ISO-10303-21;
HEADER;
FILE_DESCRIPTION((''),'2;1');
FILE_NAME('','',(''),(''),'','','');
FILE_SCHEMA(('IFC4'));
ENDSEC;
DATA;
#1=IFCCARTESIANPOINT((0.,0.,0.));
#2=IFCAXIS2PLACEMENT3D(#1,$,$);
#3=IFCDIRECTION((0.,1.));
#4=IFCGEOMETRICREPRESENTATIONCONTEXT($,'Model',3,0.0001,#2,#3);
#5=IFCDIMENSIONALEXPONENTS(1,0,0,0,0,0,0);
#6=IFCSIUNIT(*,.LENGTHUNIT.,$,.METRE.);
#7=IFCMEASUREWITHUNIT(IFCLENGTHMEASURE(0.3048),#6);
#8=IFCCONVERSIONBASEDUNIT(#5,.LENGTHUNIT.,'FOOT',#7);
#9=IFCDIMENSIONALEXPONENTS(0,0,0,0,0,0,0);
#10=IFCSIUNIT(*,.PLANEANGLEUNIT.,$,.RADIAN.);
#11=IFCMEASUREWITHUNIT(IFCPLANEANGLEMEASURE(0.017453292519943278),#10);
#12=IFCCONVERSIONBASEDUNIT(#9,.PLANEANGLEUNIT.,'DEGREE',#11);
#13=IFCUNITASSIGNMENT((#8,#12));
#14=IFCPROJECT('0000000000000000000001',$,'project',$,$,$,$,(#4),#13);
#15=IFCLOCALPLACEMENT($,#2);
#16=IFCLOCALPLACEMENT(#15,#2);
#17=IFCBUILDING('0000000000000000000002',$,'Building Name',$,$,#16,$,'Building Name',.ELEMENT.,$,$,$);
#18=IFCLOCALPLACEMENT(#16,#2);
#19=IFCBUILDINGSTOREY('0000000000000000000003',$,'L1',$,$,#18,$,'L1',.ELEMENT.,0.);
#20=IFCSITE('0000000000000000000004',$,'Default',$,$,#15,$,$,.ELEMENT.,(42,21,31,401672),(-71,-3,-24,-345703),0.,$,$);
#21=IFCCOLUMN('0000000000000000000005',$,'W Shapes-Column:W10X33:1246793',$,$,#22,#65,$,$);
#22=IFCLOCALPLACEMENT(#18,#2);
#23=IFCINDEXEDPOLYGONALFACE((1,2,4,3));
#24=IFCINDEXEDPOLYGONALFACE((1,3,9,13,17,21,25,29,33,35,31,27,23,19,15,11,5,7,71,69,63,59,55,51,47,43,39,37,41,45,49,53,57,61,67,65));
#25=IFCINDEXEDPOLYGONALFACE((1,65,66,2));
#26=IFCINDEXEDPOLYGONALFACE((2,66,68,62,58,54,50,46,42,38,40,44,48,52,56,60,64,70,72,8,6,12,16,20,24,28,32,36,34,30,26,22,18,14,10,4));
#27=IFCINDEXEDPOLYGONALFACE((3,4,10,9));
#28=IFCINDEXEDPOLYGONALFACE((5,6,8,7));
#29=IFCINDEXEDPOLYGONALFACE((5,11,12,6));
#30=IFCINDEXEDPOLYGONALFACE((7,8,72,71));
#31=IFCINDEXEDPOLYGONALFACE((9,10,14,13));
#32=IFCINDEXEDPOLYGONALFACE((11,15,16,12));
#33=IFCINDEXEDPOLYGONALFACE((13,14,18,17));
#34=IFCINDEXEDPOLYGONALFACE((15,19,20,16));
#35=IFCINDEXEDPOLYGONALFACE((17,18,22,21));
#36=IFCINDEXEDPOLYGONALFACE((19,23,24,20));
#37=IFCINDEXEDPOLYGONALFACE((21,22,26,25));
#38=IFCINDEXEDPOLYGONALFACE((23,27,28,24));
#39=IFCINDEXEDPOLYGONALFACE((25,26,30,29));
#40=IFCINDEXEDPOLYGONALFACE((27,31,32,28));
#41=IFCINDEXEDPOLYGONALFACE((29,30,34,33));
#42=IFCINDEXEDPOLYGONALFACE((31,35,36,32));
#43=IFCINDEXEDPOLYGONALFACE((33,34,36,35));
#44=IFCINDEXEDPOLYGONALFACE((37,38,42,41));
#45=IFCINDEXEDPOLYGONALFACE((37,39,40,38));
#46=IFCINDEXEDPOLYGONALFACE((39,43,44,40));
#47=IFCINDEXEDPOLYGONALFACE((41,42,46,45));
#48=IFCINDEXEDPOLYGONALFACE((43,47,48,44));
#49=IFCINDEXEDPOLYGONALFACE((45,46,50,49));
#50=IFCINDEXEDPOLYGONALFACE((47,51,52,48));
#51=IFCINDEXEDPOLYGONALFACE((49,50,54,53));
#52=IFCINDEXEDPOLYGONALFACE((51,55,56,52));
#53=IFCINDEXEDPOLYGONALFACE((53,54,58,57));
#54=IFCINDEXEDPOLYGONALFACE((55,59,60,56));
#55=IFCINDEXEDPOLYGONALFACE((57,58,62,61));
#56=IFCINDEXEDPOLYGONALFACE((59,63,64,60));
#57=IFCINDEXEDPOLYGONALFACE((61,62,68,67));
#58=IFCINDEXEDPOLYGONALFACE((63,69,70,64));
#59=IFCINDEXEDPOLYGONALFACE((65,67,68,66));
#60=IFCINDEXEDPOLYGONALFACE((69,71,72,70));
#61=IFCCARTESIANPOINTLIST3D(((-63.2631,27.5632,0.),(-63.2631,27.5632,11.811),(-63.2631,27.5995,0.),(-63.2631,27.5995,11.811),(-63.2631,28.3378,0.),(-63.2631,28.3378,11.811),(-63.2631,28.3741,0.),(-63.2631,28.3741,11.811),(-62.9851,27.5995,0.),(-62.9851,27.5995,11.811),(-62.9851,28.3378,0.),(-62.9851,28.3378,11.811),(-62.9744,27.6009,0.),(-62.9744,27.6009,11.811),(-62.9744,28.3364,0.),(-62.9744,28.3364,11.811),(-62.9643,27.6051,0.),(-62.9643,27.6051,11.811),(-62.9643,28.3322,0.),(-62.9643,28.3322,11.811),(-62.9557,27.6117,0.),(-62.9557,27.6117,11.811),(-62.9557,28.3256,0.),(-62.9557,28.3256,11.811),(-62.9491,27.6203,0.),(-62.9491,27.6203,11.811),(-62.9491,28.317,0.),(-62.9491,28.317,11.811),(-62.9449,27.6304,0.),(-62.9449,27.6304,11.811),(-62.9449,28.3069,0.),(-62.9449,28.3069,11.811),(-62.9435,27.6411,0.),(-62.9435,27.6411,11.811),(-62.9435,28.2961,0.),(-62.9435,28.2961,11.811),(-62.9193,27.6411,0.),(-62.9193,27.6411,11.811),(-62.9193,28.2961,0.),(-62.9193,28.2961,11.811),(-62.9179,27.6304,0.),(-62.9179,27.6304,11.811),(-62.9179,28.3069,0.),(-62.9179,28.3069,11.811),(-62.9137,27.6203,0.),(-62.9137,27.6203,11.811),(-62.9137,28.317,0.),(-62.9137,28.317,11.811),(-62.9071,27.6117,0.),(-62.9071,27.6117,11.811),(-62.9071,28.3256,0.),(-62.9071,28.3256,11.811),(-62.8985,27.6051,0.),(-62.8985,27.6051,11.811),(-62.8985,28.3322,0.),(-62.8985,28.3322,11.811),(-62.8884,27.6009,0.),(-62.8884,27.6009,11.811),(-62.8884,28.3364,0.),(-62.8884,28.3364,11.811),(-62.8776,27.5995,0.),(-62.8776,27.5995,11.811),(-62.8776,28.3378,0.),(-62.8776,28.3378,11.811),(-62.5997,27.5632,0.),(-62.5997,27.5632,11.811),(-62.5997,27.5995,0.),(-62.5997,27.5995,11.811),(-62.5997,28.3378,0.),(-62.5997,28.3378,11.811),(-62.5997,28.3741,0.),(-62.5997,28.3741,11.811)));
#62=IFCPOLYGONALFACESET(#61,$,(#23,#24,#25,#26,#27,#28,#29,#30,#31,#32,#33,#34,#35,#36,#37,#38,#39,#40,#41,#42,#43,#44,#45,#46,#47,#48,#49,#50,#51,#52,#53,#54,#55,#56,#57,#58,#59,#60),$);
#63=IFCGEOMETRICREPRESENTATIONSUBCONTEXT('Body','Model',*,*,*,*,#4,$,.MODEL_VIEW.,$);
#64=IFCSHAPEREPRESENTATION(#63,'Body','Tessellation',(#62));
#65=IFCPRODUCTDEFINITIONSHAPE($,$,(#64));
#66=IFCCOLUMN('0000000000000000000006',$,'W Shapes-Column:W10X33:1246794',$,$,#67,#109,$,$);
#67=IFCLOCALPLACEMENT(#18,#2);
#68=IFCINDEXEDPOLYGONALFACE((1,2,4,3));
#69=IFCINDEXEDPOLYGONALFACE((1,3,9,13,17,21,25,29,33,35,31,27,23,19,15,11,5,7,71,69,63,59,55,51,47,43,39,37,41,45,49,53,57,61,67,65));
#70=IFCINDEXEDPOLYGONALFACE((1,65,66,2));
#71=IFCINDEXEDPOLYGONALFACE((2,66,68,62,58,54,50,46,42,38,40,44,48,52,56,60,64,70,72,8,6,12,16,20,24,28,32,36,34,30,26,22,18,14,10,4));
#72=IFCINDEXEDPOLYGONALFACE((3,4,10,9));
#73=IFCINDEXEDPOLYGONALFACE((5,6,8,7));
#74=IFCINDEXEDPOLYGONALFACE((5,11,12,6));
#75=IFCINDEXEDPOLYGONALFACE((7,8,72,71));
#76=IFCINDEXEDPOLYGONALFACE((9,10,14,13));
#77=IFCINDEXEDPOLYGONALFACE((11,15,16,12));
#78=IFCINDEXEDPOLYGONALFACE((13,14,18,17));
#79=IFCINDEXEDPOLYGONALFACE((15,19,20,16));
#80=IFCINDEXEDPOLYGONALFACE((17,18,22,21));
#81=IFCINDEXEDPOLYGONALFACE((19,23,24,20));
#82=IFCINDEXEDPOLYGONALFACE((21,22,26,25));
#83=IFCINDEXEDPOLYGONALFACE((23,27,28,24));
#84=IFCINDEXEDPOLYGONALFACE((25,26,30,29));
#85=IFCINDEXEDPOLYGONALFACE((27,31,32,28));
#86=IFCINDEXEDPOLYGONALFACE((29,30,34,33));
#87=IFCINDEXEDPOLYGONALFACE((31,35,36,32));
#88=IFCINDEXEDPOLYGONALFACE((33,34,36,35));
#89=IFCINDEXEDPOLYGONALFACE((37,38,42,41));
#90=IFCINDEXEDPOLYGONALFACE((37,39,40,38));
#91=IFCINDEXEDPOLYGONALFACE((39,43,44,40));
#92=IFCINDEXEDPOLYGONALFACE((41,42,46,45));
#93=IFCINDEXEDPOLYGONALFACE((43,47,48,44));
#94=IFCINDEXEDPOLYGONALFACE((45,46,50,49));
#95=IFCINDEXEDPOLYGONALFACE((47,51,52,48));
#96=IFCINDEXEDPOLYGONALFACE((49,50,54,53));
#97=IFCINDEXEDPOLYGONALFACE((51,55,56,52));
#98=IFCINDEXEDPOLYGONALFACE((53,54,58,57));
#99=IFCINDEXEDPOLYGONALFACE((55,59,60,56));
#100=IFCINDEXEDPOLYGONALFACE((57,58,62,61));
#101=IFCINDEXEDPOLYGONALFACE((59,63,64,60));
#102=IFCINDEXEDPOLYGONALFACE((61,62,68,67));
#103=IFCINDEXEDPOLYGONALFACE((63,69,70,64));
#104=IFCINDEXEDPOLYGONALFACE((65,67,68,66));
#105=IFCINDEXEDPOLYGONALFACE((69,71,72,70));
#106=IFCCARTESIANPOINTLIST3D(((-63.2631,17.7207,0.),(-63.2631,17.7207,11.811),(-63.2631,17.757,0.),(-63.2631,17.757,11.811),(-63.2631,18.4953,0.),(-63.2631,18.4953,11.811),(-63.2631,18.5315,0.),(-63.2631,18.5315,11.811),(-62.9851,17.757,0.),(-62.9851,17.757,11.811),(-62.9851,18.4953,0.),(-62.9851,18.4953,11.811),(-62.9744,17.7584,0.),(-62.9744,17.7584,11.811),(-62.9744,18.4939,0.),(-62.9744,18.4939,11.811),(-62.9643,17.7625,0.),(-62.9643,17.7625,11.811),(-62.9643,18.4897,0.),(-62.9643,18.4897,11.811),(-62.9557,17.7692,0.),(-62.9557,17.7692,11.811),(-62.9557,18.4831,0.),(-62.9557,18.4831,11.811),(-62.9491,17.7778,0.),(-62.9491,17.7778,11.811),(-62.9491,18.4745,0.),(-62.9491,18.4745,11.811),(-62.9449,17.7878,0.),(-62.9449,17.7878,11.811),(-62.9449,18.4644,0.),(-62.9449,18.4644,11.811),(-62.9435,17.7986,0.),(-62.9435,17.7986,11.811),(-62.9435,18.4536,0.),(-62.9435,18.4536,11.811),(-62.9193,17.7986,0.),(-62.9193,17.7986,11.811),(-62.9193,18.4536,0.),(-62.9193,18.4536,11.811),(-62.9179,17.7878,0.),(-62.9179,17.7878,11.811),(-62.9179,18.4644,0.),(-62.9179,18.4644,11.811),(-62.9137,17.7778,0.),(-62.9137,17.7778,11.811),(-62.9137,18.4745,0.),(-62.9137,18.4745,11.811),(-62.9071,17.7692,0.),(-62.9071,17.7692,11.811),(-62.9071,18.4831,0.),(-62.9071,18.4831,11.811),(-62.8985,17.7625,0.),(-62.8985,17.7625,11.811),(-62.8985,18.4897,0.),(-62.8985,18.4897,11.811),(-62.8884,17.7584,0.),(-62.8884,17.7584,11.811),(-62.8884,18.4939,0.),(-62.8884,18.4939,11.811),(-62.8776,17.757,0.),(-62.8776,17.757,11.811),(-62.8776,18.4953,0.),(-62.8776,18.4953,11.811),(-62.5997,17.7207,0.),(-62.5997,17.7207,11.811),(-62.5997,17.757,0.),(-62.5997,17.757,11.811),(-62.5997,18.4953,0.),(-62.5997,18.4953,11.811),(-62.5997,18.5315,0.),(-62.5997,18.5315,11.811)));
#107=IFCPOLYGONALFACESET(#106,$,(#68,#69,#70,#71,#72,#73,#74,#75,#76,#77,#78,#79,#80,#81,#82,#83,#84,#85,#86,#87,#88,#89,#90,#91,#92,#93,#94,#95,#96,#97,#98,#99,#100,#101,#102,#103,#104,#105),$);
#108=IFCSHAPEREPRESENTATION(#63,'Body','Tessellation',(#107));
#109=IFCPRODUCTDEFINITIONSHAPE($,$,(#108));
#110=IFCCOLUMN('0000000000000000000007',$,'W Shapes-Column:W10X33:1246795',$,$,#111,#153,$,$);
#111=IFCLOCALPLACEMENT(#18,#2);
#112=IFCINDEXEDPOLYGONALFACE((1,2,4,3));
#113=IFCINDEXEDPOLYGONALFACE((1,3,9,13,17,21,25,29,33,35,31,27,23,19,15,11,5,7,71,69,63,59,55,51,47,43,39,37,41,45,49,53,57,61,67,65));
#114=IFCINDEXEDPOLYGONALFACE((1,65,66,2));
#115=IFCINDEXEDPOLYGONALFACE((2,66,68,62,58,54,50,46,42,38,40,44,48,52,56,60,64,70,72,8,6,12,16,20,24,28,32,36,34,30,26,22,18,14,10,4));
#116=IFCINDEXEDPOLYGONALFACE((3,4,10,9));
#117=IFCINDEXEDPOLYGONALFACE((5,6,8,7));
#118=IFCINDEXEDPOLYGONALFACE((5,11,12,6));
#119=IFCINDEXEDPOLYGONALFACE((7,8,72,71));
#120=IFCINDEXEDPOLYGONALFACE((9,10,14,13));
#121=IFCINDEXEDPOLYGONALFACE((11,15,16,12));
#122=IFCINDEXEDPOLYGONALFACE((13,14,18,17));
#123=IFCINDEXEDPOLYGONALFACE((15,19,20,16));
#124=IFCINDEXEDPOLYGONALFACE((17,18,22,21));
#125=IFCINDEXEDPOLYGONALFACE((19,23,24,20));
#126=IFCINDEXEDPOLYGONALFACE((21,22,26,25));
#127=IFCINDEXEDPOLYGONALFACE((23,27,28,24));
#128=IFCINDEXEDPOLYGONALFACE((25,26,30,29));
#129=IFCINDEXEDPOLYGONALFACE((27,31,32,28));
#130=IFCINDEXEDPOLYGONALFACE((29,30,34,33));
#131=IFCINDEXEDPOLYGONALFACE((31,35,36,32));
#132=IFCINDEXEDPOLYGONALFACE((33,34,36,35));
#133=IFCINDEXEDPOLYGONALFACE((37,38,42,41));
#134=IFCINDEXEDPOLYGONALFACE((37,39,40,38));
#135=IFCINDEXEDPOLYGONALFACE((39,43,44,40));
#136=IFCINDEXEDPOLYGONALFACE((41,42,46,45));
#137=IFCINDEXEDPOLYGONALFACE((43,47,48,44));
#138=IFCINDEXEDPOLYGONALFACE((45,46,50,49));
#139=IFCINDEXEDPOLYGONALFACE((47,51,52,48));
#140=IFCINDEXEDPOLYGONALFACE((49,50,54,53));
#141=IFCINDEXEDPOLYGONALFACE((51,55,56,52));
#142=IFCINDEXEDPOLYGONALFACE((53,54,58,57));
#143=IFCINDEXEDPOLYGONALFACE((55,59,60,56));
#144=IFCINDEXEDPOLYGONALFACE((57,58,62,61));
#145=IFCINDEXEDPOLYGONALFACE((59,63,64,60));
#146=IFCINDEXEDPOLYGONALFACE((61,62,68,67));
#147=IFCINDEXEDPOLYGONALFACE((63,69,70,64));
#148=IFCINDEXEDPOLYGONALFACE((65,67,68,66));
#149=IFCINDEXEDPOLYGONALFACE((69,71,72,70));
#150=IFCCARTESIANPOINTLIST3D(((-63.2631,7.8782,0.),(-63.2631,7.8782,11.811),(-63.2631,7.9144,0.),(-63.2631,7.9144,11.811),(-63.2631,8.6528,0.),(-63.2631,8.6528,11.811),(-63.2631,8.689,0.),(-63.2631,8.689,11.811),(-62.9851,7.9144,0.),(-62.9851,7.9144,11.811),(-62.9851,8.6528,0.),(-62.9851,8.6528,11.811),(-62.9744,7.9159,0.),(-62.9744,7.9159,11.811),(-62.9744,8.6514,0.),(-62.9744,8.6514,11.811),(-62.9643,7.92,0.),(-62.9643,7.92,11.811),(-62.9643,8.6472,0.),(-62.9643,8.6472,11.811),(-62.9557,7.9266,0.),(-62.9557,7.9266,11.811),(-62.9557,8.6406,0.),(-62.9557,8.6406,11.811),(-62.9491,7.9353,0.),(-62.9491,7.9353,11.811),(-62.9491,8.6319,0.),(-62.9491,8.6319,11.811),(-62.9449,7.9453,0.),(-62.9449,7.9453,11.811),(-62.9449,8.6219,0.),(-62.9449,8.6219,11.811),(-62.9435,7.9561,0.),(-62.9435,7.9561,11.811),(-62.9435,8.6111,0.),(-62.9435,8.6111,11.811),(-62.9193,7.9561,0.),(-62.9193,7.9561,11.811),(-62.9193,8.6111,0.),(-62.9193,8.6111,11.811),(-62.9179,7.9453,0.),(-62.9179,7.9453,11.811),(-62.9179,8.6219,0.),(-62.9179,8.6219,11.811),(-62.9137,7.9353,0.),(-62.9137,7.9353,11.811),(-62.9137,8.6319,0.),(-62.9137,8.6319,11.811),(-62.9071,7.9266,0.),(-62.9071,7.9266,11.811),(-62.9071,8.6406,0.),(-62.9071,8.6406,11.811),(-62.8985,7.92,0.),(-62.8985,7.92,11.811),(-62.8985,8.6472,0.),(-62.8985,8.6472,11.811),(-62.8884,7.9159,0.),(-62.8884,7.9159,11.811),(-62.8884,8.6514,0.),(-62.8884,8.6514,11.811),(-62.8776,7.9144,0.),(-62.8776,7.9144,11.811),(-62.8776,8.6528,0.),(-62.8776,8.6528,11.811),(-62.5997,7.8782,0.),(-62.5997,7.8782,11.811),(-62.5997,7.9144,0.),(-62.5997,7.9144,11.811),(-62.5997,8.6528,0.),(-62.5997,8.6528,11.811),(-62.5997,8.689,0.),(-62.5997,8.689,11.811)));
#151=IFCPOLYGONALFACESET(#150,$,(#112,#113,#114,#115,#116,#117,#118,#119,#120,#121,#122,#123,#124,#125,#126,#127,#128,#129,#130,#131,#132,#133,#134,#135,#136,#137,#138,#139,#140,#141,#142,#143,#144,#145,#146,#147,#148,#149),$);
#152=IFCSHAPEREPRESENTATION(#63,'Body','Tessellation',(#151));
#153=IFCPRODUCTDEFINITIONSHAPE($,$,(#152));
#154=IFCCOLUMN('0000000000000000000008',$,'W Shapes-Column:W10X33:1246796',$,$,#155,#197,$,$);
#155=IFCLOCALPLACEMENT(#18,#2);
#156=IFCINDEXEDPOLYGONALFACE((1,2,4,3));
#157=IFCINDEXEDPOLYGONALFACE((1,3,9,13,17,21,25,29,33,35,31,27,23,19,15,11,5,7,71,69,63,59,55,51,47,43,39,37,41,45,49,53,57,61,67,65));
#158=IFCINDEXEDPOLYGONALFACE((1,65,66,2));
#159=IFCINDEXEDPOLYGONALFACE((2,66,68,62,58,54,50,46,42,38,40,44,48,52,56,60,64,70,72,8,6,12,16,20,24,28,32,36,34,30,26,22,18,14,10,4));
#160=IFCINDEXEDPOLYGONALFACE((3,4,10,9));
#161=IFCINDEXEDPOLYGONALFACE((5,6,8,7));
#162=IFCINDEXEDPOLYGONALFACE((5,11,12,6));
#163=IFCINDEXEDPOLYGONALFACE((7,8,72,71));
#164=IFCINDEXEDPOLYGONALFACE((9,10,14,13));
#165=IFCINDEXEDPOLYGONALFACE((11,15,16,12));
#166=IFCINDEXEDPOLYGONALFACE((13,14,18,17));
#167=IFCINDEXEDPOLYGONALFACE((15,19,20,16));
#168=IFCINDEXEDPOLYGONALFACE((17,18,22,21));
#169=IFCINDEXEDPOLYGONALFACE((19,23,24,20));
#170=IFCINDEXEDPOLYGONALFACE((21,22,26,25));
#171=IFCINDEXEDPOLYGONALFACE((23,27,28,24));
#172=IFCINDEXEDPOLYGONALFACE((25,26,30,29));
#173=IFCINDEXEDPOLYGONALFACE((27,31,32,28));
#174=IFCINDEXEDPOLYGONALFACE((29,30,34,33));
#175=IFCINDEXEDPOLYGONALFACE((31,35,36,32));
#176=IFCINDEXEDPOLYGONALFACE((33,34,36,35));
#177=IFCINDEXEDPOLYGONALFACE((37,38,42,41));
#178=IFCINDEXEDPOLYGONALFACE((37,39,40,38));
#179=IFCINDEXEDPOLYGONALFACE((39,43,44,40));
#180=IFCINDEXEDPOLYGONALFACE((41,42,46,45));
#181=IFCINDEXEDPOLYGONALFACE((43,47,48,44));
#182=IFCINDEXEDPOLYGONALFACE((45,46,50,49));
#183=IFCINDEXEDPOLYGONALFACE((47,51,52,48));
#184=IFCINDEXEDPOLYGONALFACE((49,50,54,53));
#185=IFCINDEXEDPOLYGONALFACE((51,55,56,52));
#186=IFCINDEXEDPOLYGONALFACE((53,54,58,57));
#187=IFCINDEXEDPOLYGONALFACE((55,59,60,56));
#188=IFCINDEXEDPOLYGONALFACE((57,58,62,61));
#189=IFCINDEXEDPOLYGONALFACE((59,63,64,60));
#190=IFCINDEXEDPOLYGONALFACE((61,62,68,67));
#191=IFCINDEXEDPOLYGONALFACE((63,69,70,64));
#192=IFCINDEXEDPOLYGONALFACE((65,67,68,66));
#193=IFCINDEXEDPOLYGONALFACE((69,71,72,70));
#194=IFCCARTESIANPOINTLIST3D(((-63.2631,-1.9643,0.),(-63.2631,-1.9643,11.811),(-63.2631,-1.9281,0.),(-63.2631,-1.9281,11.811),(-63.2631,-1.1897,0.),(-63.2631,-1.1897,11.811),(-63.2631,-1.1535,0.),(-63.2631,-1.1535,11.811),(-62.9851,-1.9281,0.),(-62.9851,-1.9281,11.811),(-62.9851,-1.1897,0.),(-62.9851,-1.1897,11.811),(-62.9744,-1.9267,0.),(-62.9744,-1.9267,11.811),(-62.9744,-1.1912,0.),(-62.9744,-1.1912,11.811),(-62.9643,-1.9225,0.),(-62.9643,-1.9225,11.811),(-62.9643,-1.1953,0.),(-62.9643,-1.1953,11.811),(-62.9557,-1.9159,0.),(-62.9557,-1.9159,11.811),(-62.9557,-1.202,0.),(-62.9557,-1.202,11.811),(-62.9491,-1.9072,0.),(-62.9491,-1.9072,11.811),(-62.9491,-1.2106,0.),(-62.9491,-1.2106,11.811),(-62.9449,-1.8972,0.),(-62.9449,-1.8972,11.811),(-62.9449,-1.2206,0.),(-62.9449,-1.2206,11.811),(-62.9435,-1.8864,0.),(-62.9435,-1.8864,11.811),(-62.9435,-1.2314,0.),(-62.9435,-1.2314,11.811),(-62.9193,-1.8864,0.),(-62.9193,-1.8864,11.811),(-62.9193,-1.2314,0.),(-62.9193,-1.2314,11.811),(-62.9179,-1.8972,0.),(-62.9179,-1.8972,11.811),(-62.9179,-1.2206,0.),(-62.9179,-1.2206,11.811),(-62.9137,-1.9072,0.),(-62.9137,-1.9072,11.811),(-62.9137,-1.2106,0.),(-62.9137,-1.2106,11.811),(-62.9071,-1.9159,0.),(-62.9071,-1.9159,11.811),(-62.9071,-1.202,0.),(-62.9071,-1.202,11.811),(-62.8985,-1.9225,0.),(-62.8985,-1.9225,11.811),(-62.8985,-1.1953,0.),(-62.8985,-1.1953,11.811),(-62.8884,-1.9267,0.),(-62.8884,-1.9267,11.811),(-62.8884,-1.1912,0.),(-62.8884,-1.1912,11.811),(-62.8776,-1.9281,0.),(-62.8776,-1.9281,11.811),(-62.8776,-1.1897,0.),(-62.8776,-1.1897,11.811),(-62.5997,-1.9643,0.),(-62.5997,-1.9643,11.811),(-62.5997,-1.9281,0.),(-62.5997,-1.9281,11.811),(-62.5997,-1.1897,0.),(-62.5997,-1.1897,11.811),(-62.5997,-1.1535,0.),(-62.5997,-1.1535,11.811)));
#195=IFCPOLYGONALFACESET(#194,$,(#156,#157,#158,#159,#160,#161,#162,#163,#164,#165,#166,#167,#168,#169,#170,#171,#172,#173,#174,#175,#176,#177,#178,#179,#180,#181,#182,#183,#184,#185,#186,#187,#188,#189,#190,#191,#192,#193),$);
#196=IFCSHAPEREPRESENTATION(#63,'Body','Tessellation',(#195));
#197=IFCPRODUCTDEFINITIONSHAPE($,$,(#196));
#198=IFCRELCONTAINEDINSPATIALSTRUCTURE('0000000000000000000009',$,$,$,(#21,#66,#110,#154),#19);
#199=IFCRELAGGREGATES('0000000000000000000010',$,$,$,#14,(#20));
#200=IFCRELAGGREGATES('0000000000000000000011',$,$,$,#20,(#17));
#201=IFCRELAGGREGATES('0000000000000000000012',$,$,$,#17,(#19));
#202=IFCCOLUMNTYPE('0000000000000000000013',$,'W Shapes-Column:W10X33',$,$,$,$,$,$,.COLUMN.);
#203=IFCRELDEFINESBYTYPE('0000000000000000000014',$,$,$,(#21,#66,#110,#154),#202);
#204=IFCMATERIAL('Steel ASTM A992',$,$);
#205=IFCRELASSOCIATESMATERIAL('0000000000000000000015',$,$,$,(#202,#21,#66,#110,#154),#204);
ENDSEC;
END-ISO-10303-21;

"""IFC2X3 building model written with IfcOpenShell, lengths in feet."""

from ifc_helpers import new_model, entity, si_unit, converted_unit, direction, frame, frame_2d, origin, place, context, subcontext, project, spatial, i_section, extrude, source, transform, mapped, material, type_object, type_shapes, element, save


model = new_model("IFC2X3")

# Units and contexts
model_context = context("Model", 3, precision=0.0001, world=origin(), true_north=direction((0.0, 1.0)))
body_context = subcontext(model_context, "Body", "Model", "MODEL_VIEW")
ifc_project = project(units=[converted_unit("LENGTHUNIT", "FOOT", entity("IfcLengthMeasure", 0.3048), si_unit("LENGTHUNIT", "METRE"), dimensions=[1, 0, 0, 0, 0, 0, 0]), converted_unit("PLANEANGLEUNIT", "DEGREE", entity("IfcPlaneAngleMeasure", 0.017453292519943278), si_unit("PLANEANGLEUNIT", "RADIAN"), dimensions=[0, 0, 0, 0, 0, 0, 0])], contexts=[model_context])

# Site, building, storey
site_placement = place(None, origin())
site = spatial("IfcSite", under=ifc_project, at=site_placement, Name="Default", CompositionType="ELEMENT", RefLatitude=(42, 21, 31, 401672), RefLongitude=(-71, -3, -24, -345703), RefElevation=0.0)
building_placement = place(site_placement, origin())
building = spatial("IfcBuilding", under=site, at=building_placement, Name="Building Name", LongName="Building Name", CompositionType="ELEMENT")
storey_placement = place(building_placement, origin())
storey = spatial("IfcBuildingStorey", under=building, at=storey_placement, Name="L1", LongName="L1", CompositionType="ELEMENT", Elevation=0.0)

# Columns
ifc_material = material(Name="Steel ASTM A992")
column_type = type_object("IfcColumnType", Name="W Shapes-Column:W10X33", PredefinedType="COLUMN", material=ifc_material)
shared_shape = source(origin(), body_context, "Body", "SweptSolid", [
    extrude(i_section(OverallWidth=0.6633, OverallDepth=0.8108, WebThickness=0.0242, FlangeThickness=0.0362, FilletRadius=0.0417, at=frame_2d((0.0, 0.0), x_axis=(1.0, 0.0))), frame((0.0, 0.0, 0.0), z_axis=(0.0, 0.0, 1.0), x_axis=(-1.0, 0.0, 0.0)), (0.0, 0.0, 1.0), 11.811),
])
type_shapes(column_type, [shared_shape])
for number, where, name in (
    (1, (-62.9314, 27.9686, 0.0), "W Shapes-Column:W10X33:1246793"),
    (2, (-62.9314, 18.1261, 0.0), "W Shapes-Column:W10X33:1246794"),
    (3, (-62.9314, 8.2836, 0.0), "W Shapes-Column:W10X33:1246795"),
    (4, (-62.9314, -1.5589, 0.0), "W Shapes-Column:W10X33:1246796"),
):
    element("IfcColumn", number, at=place(storey_placement, frame(where)), inside=storey, type_object=column_type, material=ifc_material, Name=name, context=body_context, shape_type="MappedRepresentation", body=[
        mapped(shared_shape, transform((0.0, 0.0, 0.0), scale=1.0)),
    ])

save(model, "model.ifc")
